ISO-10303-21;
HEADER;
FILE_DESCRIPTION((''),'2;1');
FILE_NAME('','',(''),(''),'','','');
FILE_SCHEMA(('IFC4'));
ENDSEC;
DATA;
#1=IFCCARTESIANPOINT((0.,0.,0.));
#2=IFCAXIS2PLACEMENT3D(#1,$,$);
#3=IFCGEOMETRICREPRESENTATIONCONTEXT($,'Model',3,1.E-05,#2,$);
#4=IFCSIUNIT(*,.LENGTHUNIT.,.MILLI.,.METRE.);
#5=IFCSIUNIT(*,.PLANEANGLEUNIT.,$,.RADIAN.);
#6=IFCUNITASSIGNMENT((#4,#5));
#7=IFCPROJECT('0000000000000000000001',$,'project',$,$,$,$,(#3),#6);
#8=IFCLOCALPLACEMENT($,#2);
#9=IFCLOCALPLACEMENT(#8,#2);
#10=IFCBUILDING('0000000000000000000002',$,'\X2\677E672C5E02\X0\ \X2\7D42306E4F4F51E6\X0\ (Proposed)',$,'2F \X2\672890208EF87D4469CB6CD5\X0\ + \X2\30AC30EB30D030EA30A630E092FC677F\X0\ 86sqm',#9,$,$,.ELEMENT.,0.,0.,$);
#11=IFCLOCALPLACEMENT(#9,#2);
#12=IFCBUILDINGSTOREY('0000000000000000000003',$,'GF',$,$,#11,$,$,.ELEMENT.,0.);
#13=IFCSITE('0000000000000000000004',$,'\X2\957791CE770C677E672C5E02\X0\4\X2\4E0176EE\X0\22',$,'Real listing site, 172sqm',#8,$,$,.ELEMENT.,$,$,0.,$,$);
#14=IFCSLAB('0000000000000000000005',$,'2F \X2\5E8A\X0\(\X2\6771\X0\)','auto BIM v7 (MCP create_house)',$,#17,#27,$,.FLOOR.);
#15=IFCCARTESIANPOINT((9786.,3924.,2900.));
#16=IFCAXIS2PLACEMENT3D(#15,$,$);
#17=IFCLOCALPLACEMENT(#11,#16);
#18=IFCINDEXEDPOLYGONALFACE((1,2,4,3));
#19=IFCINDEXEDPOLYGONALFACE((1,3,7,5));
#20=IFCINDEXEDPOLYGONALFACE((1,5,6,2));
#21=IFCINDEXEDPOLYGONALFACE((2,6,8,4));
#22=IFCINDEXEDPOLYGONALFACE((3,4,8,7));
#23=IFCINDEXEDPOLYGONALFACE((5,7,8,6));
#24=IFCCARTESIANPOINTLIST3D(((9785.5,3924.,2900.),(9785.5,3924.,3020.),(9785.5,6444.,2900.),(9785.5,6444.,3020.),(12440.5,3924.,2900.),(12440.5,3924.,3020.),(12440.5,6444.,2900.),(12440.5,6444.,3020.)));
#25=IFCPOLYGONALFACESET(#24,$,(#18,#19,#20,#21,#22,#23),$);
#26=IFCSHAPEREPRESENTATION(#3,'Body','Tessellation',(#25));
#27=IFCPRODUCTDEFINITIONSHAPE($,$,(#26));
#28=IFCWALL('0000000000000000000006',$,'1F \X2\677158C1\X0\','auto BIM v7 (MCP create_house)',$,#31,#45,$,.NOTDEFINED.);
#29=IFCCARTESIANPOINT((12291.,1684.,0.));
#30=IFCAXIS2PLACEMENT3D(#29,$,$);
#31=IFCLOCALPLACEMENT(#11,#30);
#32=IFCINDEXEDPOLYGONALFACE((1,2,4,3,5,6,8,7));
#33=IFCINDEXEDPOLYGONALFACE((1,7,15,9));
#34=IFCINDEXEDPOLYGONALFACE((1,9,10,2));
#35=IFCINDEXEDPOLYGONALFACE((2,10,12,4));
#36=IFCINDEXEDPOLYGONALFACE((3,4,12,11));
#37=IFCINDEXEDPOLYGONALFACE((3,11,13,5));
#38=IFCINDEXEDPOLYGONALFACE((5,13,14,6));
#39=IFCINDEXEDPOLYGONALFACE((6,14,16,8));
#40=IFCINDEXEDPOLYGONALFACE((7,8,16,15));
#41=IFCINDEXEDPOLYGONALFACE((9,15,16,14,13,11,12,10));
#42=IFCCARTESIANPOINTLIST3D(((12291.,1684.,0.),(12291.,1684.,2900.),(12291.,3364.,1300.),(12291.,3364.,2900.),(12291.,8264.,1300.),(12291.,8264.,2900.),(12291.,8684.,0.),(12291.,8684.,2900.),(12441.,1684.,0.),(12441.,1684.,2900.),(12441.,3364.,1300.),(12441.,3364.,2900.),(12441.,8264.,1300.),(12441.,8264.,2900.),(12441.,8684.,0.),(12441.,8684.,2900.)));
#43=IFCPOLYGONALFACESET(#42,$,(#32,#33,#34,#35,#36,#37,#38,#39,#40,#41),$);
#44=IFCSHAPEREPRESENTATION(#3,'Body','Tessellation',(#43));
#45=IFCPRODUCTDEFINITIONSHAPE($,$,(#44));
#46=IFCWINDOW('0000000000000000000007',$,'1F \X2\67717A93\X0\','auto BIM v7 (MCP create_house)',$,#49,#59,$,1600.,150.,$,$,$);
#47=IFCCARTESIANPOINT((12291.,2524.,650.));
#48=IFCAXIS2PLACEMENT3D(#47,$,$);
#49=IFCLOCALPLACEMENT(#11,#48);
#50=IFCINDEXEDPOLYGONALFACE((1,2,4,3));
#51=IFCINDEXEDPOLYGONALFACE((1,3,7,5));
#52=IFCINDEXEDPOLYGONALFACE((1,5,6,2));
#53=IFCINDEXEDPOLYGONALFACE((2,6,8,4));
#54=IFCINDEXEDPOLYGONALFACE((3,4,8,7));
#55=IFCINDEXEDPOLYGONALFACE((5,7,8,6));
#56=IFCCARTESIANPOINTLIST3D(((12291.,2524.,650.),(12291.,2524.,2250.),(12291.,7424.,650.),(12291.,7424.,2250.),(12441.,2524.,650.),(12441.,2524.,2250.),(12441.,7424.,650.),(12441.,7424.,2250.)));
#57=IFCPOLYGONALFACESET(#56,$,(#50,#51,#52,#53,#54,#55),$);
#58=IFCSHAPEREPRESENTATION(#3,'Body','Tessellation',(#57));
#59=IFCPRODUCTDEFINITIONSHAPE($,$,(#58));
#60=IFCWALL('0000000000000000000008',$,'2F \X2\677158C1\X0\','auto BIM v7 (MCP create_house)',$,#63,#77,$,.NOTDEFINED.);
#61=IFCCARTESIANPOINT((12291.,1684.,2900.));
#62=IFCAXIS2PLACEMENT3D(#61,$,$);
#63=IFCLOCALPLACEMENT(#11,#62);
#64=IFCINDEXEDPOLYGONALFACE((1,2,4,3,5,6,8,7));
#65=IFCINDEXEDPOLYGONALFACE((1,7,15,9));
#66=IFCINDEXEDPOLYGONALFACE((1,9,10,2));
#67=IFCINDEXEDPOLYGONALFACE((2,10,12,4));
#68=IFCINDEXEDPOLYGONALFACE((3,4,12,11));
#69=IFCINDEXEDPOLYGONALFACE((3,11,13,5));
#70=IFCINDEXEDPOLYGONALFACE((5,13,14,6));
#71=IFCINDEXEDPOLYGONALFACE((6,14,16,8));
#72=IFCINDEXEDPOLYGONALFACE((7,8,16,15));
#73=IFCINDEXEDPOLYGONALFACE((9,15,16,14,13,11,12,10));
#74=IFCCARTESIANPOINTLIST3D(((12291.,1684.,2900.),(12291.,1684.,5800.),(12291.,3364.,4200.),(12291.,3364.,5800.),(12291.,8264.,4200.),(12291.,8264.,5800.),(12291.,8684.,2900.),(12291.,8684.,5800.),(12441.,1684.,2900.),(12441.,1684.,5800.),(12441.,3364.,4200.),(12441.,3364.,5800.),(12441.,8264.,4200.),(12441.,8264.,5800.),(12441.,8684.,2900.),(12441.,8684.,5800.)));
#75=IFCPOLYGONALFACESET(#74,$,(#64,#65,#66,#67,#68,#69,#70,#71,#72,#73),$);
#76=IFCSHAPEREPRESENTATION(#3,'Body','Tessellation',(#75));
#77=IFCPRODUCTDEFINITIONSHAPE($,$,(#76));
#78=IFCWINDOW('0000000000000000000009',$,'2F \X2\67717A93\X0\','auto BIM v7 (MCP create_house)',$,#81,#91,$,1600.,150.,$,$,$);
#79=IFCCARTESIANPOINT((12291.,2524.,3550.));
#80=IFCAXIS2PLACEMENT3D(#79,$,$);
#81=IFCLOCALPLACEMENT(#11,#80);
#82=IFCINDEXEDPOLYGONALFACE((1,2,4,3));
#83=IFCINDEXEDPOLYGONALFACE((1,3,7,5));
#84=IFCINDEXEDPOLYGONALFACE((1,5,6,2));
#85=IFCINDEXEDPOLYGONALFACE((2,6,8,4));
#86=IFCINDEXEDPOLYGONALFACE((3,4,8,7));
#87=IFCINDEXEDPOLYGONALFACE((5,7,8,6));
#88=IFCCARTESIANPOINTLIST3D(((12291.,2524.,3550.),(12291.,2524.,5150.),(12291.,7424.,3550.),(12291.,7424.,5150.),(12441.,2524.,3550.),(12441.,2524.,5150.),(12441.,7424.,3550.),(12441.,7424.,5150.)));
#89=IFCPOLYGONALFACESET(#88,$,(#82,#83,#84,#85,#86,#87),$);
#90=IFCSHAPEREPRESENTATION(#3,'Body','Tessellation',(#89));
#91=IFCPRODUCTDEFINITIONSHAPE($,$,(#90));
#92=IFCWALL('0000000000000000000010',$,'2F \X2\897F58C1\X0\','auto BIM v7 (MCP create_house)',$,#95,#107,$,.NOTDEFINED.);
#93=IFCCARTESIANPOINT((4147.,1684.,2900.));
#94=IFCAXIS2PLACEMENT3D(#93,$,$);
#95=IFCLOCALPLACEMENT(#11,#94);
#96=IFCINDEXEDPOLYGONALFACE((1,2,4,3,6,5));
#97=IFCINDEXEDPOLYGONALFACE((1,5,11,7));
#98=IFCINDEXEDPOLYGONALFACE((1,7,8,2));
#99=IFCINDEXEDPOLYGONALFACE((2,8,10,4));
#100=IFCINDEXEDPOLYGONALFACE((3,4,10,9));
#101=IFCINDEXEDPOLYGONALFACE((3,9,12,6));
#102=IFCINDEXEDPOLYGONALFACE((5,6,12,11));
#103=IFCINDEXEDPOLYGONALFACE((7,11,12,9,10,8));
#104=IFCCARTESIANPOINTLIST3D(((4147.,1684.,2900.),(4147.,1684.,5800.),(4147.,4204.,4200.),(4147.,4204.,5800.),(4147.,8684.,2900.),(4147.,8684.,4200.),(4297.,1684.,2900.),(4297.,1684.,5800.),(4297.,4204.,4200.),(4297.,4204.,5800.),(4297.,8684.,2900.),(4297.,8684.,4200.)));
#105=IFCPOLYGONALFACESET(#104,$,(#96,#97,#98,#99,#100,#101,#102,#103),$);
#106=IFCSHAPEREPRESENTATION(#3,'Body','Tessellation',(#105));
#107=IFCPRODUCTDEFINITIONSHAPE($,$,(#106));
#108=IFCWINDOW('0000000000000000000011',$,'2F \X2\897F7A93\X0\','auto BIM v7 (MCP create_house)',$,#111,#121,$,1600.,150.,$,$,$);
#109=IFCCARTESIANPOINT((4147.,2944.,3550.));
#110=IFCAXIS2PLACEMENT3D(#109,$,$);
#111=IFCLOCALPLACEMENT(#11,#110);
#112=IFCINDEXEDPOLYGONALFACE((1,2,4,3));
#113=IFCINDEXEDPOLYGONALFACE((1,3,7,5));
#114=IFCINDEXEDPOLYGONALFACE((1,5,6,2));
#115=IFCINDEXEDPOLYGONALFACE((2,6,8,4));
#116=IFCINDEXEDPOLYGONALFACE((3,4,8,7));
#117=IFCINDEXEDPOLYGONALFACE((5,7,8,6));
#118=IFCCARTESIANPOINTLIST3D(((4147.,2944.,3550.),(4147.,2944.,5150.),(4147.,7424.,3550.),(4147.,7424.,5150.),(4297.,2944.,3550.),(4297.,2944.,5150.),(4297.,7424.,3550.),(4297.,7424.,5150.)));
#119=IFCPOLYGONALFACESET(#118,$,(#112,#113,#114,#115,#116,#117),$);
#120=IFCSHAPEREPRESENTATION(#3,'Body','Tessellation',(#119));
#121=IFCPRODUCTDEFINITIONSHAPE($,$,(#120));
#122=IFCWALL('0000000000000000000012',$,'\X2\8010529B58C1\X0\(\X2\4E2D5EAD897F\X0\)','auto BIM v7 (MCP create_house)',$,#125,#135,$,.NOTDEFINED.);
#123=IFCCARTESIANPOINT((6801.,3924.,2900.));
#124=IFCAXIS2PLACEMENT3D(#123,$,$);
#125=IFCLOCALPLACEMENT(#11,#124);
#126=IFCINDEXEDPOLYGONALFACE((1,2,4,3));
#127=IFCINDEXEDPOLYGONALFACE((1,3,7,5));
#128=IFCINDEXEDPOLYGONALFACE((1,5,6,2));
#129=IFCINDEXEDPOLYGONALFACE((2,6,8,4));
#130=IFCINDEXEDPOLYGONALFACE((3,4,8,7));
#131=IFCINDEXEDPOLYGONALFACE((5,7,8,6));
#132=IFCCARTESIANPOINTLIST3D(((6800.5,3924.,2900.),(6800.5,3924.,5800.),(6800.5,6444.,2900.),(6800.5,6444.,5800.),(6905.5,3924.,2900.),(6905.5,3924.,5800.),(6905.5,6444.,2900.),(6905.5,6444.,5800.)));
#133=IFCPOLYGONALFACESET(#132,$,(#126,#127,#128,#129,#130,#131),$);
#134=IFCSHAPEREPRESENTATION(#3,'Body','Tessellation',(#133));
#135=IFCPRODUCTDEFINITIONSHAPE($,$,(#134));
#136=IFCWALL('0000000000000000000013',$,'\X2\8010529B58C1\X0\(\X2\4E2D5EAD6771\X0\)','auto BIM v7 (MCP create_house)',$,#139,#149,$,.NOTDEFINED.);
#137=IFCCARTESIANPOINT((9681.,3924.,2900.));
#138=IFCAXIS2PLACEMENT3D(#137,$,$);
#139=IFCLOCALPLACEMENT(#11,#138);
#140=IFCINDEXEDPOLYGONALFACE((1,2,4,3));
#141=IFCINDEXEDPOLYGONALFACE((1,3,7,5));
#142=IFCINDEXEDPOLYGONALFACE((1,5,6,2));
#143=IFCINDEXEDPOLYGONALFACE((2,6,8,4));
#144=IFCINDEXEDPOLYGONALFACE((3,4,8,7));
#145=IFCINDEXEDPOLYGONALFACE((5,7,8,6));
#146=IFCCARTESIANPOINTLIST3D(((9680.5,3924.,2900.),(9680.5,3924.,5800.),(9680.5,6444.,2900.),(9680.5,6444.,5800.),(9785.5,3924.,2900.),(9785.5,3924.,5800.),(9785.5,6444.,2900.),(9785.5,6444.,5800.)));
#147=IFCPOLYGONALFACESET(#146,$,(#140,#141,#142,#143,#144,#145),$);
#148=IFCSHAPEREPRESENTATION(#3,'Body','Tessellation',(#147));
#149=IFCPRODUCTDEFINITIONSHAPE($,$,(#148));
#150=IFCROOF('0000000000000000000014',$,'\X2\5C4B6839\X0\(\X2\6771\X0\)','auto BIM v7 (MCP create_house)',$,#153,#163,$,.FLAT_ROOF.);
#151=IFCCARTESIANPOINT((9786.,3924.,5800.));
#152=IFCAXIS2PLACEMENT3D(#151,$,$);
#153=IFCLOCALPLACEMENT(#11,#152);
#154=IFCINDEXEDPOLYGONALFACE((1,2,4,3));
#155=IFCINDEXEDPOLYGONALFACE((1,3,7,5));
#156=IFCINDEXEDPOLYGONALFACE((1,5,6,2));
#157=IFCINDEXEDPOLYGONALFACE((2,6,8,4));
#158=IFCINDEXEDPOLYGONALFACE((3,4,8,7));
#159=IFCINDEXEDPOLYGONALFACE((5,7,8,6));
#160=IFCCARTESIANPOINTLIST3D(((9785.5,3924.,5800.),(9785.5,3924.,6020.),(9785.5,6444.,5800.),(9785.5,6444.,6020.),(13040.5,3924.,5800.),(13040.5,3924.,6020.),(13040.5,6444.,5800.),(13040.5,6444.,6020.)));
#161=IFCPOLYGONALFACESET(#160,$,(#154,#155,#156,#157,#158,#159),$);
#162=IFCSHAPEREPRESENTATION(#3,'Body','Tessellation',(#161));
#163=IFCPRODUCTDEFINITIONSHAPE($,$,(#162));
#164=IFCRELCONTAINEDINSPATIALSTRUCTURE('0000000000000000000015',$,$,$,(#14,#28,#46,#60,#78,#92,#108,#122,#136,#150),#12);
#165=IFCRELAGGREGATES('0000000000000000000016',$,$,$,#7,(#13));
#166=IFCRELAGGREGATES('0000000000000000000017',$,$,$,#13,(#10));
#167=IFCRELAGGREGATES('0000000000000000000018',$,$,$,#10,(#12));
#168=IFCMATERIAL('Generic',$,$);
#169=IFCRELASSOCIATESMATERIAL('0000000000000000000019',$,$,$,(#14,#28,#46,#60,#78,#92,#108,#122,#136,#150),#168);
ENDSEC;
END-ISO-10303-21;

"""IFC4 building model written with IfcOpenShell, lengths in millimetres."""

from ifc_helpers import new_model, si_unit, frame, frame_2d, origin, place, context, project, spatial, rectangle, extrude, material, element, fill, save


model = new_model("IFC4")

# Units and contexts
model_context = context("Model", 3, precision=1e-05, world=origin())
ifc_project = project(units=[si_unit("LENGTHUNIT", "METRE", prefix="MILLI"), si_unit("PLANEANGLEUNIT", "RADIAN")], contexts=[model_context])

# Site, building, storey
site_placement = place(None, origin())
site = spatial("IfcSite", under=ifc_project, at=site_placement, Name="長野県松本市4丁目22", ObjectType="Real listing site, 172sqm", CompositionType="ELEMENT", RefElevation=0.0)
building_placement = place(site_placement, origin())
building = spatial("IfcBuilding", under=site, at=building_placement, Name="松本市 終の住処 (Proposed)", ObjectType="2F 木造軸組構法 + ガルバリウム鋼板 86sqm", CompositionType="ELEMENT", ElevationOfRefHeight=0.0, ElevationOfTerrain=0.0)
storey_placement = place(building_placement, origin())
storey = spatial("IfcBuildingStorey", under=building, at=storey_placement, Name="GF", CompositionType="ELEMENT", Elevation=0.0)

# Slab
ifc_material = material(Name="Generic")
slab_1_placement = place(storey_placement, frame((9786.0, 3924.0, 2900.0)))
element("IfcSlab", 1, at=slab_1_placement, inside=storey, material=ifc_material, Name="2F 床(東)", Description="auto BIM v7 (MCP create_house)", PredefinedType="FLOOR", context=model_context, shape_type="SweptSolid", body=[
    extrude(rectangle(XDim=2655.0, YDim=2520.0, at=frame_2d((1327.0, 1260.0))), frame((9786.0, 3924.0, 2900.0)), (0.0, 0.0, 1.0), 120.0),
])

# Wall, opening, window
wall_1_placement = place(storey_placement, frame((12291.0, 1684.0, 0.0)))
wall_1 = element("IfcWall", 2, at=wall_1_placement, inside=storey, material=ifc_material, Name="1F 東壁", Description="auto BIM v7 (MCP create_house)", PredefinedType="NOTDEFINED", context=model_context, shape_type="SweptSolid", body=[
    extrude(rectangle(XDim=150.0, YDim=7000.0, at=frame_2d((75.0, 3500.0))), frame((12291.0, 1684.0, 0.0)), (0.0, 0.0, 1.0), 2900.0),
])
opening_1_placement = place(storey_placement, frame((12291.0, 2524.0, 650.0)))
opening_1 = element("IfcOpeningElement", 3, at=opening_1_placement, cuts=wall_1, PredefinedType="NOTDEFINED", context=model_context, shape_type="SweptSolid", body=[
    extrude(rectangle(XDim=150.0, YDim=4900.0, at=frame_2d((75.0, 2450.0))), frame((12291.0, 2524.0, 650.0)), (0.0, 0.0, 1.0), 1600.0),
])
window_1_placement = place(storey_placement, frame((12291.0, 2524.0, 650.0)))
window_1 = element("IfcWindow", 4, at=window_1_placement, inside=storey, material=ifc_material, Name="1F 東窓", Description="auto BIM v7 (MCP create_house)", OverallHeight=1600.0, OverallWidth=150.0, context=model_context, shape_type="SweptSolid", body=[
    extrude(rectangle(XDim=150.0, YDim=4900.0, at=frame_2d((75.0, 2450.0))), frame((12291.0, 2524.0, 650.0)), (0.0, 0.0, 1.0), 1600.0),
])
fill(opening_1, window_1)

# Walls, openings, windows
wall_2_placement = place(storey_placement, frame((12291.0, 1684.0, 2900.0)))
wall_2 = element("IfcWall", 5, at=wall_2_placement, inside=storey, material=ifc_material, Name="2F 東壁", Description="auto BIM v7 (MCP create_house)", PredefinedType="NOTDEFINED", context=model_context, shape_type="SweptSolid", body=[
    extrude(rectangle(XDim=150.0, YDim=7000.0, at=frame_2d((75.0, 3500.0))), frame((12291.0, 1684.0, 2900.0)), (0.0, 0.0, 1.0), 2900.0),
])
opening_2_placement = place(storey_placement, frame((12291.0, 2524.0, 3550.0)))
opening_2 = element("IfcOpeningElement", 6, at=opening_2_placement, cuts=wall_2, PredefinedType="NOTDEFINED", context=model_context, shape_type="SweptSolid", body=[
    extrude(rectangle(XDim=150.0, YDim=4900.0, at=frame_2d((75.0, 2450.0))), frame((12291.0, 2524.0, 3550.0)), (0.0, 0.0, 1.0), 1600.0),
])
window_2_placement = place(storey_placement, frame((12291.0, 2524.0, 3550.0)))
window_2 = element("IfcWindow", 7, at=window_2_placement, inside=storey, material=ifc_material, Name="2F 東窓", Description="auto BIM v7 (MCP create_house)", OverallHeight=1600.0, OverallWidth=150.0, context=model_context, shape_type="SweptSolid", body=[
    extrude(rectangle(XDim=150.0, YDim=4900.0, at=frame_2d((75.0, 2450.0))), frame((12291.0, 2524.0, 3550.0)), (0.0, 0.0, 1.0), 1600.0),
])
fill(opening_2, window_2)
wall_3_placement = place(storey_placement, frame((4147.0, 1684.0, 2900.0)))
wall_3 = element("IfcWall", 8, at=wall_3_placement, inside=storey, material=ifc_material, Name="2F 西壁", Description="auto BIM v7 (MCP create_house)", PredefinedType="NOTDEFINED", context=model_context, shape_type="SweptSolid", body=[
    extrude(rectangle(XDim=150.0, YDim=7000.0, at=frame_2d((75.0, 3500.0))), frame((4147.0, 1684.0, 2900.0)), (0.0, 0.0, 1.0), 2900.0),
])
opening_3_placement = place(storey_placement, frame((4147.0, 2944.0, 3550.0)))
opening_3 = element("IfcOpeningElement", 9, at=opening_3_placement, cuts=wall_3, PredefinedType="NOTDEFINED", context=model_context, shape_type="SweptSolid", body=[
    extrude(rectangle(XDim=150.0, YDim=4480.0, at=frame_2d((75.0, 2240.0))), frame((4147.0, 2944.0, 3550.0)), (0.0, 0.0, 1.0), 1600.0),
])
window_3_placement = place(storey_placement, frame((4147.0, 2944.0, 3550.0)))
window_3 = element("IfcWindow", 10, at=window_3_placement, inside=storey, material=ifc_material, Name="2F 西窓", Description="auto BIM v7 (MCP create_house)", OverallHeight=1600.0, OverallWidth=150.0, context=model_context, shape_type="SweptSolid", body=[
    extrude(rectangle(XDim=150.0, YDim=4480.0, at=frame_2d((75.0, 2240.0))), frame((4147.0, 2944.0, 3550.0)), (0.0, 0.0, 1.0), 1600.0),
])
fill(opening_3, window_3)

# Walls
wall_4_placement = place(storey_placement, frame((6801.0, 3924.0, 2900.0)))
element("IfcWall", 11, at=wall_4_placement, inside=storey, material=ifc_material, Name="耐力壁(中庭西)", Description="auto BIM v7 (MCP create_house)", PredefinedType="NOTDEFINED", context=model_context, shape_type="SweptSolid", body=[
    extrude(rectangle(XDim=105.0, YDim=2520.0, at=frame_2d((52.0, 1260.0))), frame((6801.0, 3924.0, 2900.0)), (0.0, 0.0, 1.0), 2900.0),
])
wall_5_placement = place(storey_placement, frame((9681.0, 3924.0, 2900.0)))
element("IfcWall", 12, at=wall_5_placement, inside=storey, material=ifc_material, Name="耐力壁(中庭東)", Description="auto BIM v7 (MCP create_house)", PredefinedType="NOTDEFINED", context=model_context, shape_type="SweptSolid", body=[
    extrude(rectangle(XDim=105.0, YDim=2520.0, at=frame_2d((52.0, 1260.0))), frame((9681.0, 3924.0, 2900.0)), (0.0, 0.0, 1.0), 2900.0),
])

# Roof
for number, where, name in (
    (13, (9786.0, 3924.0, 5800.0), "屋根(東)"),
):
    element("IfcRoof", number, at=place(storey_placement, frame(where)), inside=storey, material=ifc_material, Name=name, Description="auto BIM v7 (MCP create_house)", PredefinedType="FLAT_ROOF", context=model_context, shape_type="SweptSolid", body=[
        extrude(rectangle(XDim=3255.0, YDim=2520.0, at=frame_2d((1627.0, 1260.0))), frame((9786.0, 3924.0, 5800.0)), (0.0, 0.0, 1.0), 220.0),
    ])

save(model, "model.ifc")
